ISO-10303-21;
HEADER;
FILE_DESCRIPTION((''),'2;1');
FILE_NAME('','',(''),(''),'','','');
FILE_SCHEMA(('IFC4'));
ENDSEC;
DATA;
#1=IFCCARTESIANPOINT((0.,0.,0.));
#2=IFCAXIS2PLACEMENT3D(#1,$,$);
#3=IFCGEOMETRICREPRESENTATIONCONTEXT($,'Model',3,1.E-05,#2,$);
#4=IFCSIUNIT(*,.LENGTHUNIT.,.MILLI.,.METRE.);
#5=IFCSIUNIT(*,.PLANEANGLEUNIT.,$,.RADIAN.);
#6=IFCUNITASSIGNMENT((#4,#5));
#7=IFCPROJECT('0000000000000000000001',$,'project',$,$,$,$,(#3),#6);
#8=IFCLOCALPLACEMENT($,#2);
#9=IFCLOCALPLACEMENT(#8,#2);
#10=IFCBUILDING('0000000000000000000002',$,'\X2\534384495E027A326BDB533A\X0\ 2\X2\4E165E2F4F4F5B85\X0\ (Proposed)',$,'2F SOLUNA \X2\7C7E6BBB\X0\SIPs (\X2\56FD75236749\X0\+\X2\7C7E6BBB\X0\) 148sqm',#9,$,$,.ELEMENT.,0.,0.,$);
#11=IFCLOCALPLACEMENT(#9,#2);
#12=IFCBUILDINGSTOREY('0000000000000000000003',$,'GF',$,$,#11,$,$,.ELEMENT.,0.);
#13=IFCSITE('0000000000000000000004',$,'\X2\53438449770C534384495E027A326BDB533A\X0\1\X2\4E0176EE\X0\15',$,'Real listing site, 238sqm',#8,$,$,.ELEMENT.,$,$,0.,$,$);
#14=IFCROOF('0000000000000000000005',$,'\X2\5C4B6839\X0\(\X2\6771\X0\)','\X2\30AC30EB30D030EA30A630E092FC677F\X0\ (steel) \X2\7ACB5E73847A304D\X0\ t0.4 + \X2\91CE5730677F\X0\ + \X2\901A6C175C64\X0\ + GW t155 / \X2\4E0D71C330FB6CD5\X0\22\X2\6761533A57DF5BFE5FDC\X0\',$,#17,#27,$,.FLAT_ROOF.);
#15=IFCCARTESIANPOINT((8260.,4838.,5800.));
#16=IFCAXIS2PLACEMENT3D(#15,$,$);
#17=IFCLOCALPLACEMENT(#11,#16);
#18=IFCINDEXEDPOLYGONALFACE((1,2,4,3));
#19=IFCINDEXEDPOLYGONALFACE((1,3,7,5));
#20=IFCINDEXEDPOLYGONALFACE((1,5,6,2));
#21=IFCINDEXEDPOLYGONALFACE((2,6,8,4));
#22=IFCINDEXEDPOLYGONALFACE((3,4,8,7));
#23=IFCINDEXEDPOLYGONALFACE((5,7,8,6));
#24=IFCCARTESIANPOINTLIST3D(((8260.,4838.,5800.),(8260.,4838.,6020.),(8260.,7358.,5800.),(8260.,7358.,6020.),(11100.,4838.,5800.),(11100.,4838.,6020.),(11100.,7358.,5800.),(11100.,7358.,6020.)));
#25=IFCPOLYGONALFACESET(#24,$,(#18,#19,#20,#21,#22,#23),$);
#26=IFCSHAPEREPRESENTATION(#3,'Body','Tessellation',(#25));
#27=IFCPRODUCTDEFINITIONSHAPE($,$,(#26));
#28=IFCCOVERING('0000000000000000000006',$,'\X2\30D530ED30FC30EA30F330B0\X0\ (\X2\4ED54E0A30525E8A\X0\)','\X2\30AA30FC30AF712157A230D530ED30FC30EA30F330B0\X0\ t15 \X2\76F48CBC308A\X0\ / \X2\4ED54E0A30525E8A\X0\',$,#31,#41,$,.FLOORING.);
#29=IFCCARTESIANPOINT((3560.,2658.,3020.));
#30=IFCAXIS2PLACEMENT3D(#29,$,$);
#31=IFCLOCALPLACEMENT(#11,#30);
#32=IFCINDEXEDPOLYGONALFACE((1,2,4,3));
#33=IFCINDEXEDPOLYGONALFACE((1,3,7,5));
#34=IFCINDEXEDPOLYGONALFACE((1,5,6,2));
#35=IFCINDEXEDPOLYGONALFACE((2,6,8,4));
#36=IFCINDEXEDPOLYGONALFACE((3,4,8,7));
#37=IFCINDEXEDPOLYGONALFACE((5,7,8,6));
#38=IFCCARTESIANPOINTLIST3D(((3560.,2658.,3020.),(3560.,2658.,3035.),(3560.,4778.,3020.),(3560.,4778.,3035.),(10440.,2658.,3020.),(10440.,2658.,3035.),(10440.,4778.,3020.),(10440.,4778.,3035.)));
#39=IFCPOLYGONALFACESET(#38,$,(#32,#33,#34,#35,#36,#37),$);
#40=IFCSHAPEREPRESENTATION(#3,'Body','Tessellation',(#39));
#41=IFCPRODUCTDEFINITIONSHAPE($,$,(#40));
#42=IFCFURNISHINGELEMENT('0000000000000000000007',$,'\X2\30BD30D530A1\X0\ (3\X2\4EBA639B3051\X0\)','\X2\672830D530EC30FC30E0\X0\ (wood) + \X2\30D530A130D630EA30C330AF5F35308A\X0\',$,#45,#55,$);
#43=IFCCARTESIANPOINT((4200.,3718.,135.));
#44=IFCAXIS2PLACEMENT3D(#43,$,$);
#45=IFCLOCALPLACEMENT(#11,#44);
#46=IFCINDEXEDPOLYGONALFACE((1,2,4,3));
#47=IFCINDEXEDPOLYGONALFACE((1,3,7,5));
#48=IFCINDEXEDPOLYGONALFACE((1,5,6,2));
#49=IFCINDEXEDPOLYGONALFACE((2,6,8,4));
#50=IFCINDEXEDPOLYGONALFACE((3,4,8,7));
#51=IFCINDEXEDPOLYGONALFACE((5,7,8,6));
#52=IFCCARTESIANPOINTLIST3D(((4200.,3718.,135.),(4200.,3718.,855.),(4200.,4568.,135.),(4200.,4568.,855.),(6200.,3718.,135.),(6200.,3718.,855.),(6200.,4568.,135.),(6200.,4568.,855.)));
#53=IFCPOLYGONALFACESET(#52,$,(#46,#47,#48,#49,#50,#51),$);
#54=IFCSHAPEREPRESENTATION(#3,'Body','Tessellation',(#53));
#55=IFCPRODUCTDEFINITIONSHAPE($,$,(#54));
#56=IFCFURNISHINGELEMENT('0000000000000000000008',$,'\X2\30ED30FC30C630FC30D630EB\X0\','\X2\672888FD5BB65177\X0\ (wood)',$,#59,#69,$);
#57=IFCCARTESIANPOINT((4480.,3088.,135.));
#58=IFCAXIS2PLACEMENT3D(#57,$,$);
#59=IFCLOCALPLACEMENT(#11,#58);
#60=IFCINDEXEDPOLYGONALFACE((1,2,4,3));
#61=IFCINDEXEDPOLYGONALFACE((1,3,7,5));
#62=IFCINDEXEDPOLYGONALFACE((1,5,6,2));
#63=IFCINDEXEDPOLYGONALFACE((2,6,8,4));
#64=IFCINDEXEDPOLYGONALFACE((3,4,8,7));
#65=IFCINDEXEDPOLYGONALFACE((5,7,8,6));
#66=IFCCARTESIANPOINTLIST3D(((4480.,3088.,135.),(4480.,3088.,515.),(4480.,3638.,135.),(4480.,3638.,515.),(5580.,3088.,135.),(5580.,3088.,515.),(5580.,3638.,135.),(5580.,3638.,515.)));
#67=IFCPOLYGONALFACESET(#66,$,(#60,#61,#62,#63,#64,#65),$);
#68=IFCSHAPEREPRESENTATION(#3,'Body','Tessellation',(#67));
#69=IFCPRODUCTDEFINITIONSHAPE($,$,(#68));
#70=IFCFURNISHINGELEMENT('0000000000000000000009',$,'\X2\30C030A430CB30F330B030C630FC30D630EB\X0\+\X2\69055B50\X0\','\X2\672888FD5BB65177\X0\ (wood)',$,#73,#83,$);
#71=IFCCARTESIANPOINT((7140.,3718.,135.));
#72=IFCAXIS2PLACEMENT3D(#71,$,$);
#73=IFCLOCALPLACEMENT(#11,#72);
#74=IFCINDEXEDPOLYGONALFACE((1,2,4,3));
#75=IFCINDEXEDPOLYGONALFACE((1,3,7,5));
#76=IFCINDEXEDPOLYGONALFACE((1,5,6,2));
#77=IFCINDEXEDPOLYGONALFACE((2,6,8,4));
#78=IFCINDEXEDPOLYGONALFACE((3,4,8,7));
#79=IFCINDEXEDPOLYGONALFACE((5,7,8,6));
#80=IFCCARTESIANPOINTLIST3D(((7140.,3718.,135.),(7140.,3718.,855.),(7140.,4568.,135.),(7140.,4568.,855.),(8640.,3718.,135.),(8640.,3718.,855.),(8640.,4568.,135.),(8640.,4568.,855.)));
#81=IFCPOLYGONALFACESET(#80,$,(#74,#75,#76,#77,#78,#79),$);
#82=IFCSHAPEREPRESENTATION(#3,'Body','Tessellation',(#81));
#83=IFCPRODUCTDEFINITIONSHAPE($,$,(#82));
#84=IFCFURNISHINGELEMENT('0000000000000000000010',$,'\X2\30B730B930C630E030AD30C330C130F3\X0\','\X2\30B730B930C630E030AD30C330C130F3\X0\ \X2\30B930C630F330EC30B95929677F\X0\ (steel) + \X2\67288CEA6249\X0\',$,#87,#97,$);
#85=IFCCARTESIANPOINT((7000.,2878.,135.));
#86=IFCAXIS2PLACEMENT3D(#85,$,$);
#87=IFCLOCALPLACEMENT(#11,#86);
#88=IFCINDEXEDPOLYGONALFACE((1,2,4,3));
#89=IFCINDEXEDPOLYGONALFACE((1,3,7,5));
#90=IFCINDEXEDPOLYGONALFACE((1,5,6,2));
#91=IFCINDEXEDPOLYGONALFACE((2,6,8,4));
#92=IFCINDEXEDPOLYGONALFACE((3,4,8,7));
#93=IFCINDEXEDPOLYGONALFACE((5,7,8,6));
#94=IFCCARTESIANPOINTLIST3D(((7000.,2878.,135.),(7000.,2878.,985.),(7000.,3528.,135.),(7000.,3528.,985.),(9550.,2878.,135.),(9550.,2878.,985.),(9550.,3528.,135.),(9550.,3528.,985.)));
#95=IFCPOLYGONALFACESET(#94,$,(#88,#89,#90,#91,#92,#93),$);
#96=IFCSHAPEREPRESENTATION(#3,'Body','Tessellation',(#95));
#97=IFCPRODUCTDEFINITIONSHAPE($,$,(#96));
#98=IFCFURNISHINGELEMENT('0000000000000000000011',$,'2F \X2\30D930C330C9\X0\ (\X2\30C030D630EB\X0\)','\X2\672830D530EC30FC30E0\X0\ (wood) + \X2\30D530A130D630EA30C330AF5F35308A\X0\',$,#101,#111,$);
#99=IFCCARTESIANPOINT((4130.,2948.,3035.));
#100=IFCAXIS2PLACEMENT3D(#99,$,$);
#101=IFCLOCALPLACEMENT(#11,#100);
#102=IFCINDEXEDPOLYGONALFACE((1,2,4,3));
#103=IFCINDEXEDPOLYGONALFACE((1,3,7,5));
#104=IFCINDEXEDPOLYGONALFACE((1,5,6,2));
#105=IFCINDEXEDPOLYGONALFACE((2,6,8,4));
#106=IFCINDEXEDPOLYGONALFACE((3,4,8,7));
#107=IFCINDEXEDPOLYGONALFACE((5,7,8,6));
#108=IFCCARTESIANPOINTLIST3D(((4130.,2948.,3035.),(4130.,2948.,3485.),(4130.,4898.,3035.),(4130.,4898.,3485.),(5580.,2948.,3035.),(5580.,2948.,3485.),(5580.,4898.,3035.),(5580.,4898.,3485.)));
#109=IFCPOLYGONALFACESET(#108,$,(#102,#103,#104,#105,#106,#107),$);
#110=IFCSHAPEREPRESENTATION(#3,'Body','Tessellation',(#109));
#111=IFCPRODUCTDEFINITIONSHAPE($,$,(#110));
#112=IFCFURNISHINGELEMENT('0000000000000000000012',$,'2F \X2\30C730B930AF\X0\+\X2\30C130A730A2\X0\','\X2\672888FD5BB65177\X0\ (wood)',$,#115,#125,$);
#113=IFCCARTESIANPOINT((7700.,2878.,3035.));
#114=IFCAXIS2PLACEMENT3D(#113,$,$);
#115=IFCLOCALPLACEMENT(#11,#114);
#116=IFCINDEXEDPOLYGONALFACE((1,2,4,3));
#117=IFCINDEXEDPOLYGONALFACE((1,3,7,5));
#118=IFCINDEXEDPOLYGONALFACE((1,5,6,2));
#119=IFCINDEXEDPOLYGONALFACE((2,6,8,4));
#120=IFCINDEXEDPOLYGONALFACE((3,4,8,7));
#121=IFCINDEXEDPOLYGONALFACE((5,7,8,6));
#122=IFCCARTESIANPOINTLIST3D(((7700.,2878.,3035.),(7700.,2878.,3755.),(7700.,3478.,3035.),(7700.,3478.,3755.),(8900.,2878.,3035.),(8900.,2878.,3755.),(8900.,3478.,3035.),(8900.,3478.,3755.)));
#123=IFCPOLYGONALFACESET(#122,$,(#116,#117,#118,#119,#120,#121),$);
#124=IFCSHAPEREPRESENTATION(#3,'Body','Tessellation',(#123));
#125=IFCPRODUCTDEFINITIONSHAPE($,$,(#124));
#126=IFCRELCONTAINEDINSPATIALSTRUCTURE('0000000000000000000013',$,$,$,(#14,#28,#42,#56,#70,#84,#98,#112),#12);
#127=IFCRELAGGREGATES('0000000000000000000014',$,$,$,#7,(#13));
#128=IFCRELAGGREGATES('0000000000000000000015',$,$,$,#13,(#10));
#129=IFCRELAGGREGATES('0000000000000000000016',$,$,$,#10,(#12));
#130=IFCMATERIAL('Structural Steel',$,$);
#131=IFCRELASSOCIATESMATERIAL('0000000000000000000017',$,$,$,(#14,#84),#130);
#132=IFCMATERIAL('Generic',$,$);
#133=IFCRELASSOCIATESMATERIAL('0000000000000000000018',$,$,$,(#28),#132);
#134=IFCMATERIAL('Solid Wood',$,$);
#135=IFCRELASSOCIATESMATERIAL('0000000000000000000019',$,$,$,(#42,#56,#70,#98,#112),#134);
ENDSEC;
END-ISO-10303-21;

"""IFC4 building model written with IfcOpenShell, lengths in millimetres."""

from ifc_helpers import new_model, si_unit, frame, frame_2d, origin, place, context, project, spatial, rectangle, extrude, material, element, save


model = new_model("IFC4")

# Units and contexts
model_context = context("Model", 3, precision=1e-05, world=origin())
ifc_project = project(units=[si_unit("LENGTHUNIT", "METRE", prefix="MILLI"), si_unit("PLANEANGLEUNIT", "RADIAN")], contexts=[model_context])

# Site, building, storey
site_placement = place(None, origin())
site = spatial("IfcSite", under=ifc_project, at=site_placement, Name="千葉県千葉市稲毛区1丁目15", ObjectType="Real listing site, 238sqm", CompositionType="ELEMENT", RefElevation=0.0)
building_placement = place(site_placement, origin())
building = spatial("IfcBuilding", under=site, at=building_placement, Name="千葉市稲毛区 2世帯住宅 (Proposed)", ObjectType="2F SOLUNA 籾殻SIPs (国産杉+籾殻) 148sqm", CompositionType="ELEMENT", ElevationOfRefHeight=0.0, ElevationOfTerrain=0.0)
storey_placement = place(building_placement, origin())
storey = spatial("IfcBuildingStorey", under=building, at=storey_placement, Name="GF", CompositionType="ELEMENT", Elevation=0.0)

# Shared definitions
ifc_material_1 = material(Name="Solid Wood")

# Shared definitions
ifc_material_2 = material(Name="Generic")

# Roof
ifc_material_3 = material(Name="Structural Steel")
roof_placement = place(storey_placement, frame((8260.0, 4838.0, 5800.0)))
element("IfcRoof", 1, at=roof_placement, inside=storey, material=ifc_material_3, Name="屋根(東)", Description="ガルバリウム鋼板 (steel) 立平葺き t0.4 + 野地板 + 通気層 + GW t155 / 不燃・法22条区域対応", PredefinedType="FLAT_ROOF", context=model_context, shape_type="SweptSolid", body=[
    extrude(rectangle(XDim=2840.0, YDim=2520.0, at=frame_2d((1420.0, 1260.0))), frame((8260.0, 4838.0, 5800.0)), (0.0, 0.0, 1.0), 220.0),
])

# Covering
covering_placement = place(storey_placement, frame((3560.0, 2658.0, 3020.0)))
element("IfcCovering", 2, at=covering_placement, inside=storey, material=ifc_material_2, Name="フローリング (仕上げ床)", Description="オーク無垢フローリング t15 直貼り / 仕上げ床", PredefinedType="FLOORING", context=model_context, shape_type="SweptSolid", body=[
    extrude(rectangle(XDim=6880.0, YDim=2120.0, at=frame_2d((3440.0, 1060.0))), frame((3560.0, 2658.0, 3020.0)), (0.0, 0.0, 1.0), 15.0),
])

# Furnishing elements
furnishing_1_placement = place(storey_placement, frame((4200.0, 3718.0, 135.0)))
element("IfcFurnishingElement", 3, at=furnishing_1_placement, inside=storey, material=ifc_material_1, Name="ソファ (3人掛け)", Description="木フレーム (wood) + ファブリック張り", context=model_context, shape_type="SweptSolid", body=[
    extrude(rectangle(XDim=2000.0, YDim=850.0, at=frame_2d((1000.0, 425.0))), frame((4200.0, 3718.0, 135.0)), (0.0, 0.0, 1.0), 720.0),
])
furnishing_2_placement = place(storey_placement, frame((4480.0, 3088.0, 135.0)))
element("IfcFurnishingElement", 4, at=furnishing_2_placement, inside=storey, material=ifc_material_1, Name="ローテーブル", Description="木製家具 (wood)", context=model_context, shape_type="SweptSolid", body=[
    extrude(rectangle(XDim=1100.0, YDim=550.0, at=frame_2d((550.0, 275.0))), frame((4480.0, 3088.0, 135.0)), (0.0, 0.0, 1.0), 380.0),
])
furnishing_3_placement = place(storey_placement, frame((7140.0, 3718.0, 135.0)))
element("IfcFurnishingElement", 5, at=furnishing_3_placement, inside=storey, material=ifc_material_1, Name="ダイニングテーブル+椅子", Description="木製家具 (wood)", context=model_context, shape_type="SweptSolid", body=[
    extrude(rectangle(XDim=1500.0, YDim=850.0, at=frame_2d((750.0, 425.0))), frame((7140.0, 3718.0, 135.0)), (0.0, 0.0, 1.0), 720.0),
])
furnishing_4_placement = place(storey_placement, frame((7000.0, 2878.0, 135.0)))
element("IfcFurnishingElement", 6, at=furnishing_4_placement, inside=storey, material=ifc_material_3, Name="システムキッチン", Description="システムキッチン ステンレス天板 (steel) + 木質扉", context=model_context, shape_type="SweptSolid", body=[
    extrude(rectangle(XDim=2550.0, YDim=650.0, at=frame_2d((1275.0, 325.0))), frame((7000.0, 2878.0, 135.0)), (0.0, 0.0, 1.0), 850.0),
])
furnishing_5_placement = place(storey_placement, frame((4130.0, 2948.0, 3035.0)))
element("IfcFurnishingElement", 7, at=furnishing_5_placement, inside=storey, material=ifc_material_1, Name="2F ベッド (ダブル)", Description="木フレーム (wood) + ファブリック張り", context=model_context, shape_type="SweptSolid", body=[
    extrude(rectangle(XDim=1450.0, YDim=1950.0, at=frame_2d((725.0, 975.0))), frame((4130.0, 2948.0, 3035.0)), (0.0, 0.0, 1.0), 450.0),
])
furnishing_6_placement = place(storey_placement, frame((7700.0, 2878.0, 3035.0)))
element("IfcFurnishingElement", 8, at=furnishing_6_placement, inside=storey, material=ifc_material_1, Name="2F デスク+チェア", Description="木製家具 (wood)", context=model_context, shape_type="SweptSolid", body=[
    extrude(rectangle(XDim=1200.0, YDim=600.0, at=frame_2d((600.0, 300.0))), frame((7700.0, 2878.0, 3035.0)), (0.0, 0.0, 1.0), 720.0),
])

save(model, "model.ifc")
